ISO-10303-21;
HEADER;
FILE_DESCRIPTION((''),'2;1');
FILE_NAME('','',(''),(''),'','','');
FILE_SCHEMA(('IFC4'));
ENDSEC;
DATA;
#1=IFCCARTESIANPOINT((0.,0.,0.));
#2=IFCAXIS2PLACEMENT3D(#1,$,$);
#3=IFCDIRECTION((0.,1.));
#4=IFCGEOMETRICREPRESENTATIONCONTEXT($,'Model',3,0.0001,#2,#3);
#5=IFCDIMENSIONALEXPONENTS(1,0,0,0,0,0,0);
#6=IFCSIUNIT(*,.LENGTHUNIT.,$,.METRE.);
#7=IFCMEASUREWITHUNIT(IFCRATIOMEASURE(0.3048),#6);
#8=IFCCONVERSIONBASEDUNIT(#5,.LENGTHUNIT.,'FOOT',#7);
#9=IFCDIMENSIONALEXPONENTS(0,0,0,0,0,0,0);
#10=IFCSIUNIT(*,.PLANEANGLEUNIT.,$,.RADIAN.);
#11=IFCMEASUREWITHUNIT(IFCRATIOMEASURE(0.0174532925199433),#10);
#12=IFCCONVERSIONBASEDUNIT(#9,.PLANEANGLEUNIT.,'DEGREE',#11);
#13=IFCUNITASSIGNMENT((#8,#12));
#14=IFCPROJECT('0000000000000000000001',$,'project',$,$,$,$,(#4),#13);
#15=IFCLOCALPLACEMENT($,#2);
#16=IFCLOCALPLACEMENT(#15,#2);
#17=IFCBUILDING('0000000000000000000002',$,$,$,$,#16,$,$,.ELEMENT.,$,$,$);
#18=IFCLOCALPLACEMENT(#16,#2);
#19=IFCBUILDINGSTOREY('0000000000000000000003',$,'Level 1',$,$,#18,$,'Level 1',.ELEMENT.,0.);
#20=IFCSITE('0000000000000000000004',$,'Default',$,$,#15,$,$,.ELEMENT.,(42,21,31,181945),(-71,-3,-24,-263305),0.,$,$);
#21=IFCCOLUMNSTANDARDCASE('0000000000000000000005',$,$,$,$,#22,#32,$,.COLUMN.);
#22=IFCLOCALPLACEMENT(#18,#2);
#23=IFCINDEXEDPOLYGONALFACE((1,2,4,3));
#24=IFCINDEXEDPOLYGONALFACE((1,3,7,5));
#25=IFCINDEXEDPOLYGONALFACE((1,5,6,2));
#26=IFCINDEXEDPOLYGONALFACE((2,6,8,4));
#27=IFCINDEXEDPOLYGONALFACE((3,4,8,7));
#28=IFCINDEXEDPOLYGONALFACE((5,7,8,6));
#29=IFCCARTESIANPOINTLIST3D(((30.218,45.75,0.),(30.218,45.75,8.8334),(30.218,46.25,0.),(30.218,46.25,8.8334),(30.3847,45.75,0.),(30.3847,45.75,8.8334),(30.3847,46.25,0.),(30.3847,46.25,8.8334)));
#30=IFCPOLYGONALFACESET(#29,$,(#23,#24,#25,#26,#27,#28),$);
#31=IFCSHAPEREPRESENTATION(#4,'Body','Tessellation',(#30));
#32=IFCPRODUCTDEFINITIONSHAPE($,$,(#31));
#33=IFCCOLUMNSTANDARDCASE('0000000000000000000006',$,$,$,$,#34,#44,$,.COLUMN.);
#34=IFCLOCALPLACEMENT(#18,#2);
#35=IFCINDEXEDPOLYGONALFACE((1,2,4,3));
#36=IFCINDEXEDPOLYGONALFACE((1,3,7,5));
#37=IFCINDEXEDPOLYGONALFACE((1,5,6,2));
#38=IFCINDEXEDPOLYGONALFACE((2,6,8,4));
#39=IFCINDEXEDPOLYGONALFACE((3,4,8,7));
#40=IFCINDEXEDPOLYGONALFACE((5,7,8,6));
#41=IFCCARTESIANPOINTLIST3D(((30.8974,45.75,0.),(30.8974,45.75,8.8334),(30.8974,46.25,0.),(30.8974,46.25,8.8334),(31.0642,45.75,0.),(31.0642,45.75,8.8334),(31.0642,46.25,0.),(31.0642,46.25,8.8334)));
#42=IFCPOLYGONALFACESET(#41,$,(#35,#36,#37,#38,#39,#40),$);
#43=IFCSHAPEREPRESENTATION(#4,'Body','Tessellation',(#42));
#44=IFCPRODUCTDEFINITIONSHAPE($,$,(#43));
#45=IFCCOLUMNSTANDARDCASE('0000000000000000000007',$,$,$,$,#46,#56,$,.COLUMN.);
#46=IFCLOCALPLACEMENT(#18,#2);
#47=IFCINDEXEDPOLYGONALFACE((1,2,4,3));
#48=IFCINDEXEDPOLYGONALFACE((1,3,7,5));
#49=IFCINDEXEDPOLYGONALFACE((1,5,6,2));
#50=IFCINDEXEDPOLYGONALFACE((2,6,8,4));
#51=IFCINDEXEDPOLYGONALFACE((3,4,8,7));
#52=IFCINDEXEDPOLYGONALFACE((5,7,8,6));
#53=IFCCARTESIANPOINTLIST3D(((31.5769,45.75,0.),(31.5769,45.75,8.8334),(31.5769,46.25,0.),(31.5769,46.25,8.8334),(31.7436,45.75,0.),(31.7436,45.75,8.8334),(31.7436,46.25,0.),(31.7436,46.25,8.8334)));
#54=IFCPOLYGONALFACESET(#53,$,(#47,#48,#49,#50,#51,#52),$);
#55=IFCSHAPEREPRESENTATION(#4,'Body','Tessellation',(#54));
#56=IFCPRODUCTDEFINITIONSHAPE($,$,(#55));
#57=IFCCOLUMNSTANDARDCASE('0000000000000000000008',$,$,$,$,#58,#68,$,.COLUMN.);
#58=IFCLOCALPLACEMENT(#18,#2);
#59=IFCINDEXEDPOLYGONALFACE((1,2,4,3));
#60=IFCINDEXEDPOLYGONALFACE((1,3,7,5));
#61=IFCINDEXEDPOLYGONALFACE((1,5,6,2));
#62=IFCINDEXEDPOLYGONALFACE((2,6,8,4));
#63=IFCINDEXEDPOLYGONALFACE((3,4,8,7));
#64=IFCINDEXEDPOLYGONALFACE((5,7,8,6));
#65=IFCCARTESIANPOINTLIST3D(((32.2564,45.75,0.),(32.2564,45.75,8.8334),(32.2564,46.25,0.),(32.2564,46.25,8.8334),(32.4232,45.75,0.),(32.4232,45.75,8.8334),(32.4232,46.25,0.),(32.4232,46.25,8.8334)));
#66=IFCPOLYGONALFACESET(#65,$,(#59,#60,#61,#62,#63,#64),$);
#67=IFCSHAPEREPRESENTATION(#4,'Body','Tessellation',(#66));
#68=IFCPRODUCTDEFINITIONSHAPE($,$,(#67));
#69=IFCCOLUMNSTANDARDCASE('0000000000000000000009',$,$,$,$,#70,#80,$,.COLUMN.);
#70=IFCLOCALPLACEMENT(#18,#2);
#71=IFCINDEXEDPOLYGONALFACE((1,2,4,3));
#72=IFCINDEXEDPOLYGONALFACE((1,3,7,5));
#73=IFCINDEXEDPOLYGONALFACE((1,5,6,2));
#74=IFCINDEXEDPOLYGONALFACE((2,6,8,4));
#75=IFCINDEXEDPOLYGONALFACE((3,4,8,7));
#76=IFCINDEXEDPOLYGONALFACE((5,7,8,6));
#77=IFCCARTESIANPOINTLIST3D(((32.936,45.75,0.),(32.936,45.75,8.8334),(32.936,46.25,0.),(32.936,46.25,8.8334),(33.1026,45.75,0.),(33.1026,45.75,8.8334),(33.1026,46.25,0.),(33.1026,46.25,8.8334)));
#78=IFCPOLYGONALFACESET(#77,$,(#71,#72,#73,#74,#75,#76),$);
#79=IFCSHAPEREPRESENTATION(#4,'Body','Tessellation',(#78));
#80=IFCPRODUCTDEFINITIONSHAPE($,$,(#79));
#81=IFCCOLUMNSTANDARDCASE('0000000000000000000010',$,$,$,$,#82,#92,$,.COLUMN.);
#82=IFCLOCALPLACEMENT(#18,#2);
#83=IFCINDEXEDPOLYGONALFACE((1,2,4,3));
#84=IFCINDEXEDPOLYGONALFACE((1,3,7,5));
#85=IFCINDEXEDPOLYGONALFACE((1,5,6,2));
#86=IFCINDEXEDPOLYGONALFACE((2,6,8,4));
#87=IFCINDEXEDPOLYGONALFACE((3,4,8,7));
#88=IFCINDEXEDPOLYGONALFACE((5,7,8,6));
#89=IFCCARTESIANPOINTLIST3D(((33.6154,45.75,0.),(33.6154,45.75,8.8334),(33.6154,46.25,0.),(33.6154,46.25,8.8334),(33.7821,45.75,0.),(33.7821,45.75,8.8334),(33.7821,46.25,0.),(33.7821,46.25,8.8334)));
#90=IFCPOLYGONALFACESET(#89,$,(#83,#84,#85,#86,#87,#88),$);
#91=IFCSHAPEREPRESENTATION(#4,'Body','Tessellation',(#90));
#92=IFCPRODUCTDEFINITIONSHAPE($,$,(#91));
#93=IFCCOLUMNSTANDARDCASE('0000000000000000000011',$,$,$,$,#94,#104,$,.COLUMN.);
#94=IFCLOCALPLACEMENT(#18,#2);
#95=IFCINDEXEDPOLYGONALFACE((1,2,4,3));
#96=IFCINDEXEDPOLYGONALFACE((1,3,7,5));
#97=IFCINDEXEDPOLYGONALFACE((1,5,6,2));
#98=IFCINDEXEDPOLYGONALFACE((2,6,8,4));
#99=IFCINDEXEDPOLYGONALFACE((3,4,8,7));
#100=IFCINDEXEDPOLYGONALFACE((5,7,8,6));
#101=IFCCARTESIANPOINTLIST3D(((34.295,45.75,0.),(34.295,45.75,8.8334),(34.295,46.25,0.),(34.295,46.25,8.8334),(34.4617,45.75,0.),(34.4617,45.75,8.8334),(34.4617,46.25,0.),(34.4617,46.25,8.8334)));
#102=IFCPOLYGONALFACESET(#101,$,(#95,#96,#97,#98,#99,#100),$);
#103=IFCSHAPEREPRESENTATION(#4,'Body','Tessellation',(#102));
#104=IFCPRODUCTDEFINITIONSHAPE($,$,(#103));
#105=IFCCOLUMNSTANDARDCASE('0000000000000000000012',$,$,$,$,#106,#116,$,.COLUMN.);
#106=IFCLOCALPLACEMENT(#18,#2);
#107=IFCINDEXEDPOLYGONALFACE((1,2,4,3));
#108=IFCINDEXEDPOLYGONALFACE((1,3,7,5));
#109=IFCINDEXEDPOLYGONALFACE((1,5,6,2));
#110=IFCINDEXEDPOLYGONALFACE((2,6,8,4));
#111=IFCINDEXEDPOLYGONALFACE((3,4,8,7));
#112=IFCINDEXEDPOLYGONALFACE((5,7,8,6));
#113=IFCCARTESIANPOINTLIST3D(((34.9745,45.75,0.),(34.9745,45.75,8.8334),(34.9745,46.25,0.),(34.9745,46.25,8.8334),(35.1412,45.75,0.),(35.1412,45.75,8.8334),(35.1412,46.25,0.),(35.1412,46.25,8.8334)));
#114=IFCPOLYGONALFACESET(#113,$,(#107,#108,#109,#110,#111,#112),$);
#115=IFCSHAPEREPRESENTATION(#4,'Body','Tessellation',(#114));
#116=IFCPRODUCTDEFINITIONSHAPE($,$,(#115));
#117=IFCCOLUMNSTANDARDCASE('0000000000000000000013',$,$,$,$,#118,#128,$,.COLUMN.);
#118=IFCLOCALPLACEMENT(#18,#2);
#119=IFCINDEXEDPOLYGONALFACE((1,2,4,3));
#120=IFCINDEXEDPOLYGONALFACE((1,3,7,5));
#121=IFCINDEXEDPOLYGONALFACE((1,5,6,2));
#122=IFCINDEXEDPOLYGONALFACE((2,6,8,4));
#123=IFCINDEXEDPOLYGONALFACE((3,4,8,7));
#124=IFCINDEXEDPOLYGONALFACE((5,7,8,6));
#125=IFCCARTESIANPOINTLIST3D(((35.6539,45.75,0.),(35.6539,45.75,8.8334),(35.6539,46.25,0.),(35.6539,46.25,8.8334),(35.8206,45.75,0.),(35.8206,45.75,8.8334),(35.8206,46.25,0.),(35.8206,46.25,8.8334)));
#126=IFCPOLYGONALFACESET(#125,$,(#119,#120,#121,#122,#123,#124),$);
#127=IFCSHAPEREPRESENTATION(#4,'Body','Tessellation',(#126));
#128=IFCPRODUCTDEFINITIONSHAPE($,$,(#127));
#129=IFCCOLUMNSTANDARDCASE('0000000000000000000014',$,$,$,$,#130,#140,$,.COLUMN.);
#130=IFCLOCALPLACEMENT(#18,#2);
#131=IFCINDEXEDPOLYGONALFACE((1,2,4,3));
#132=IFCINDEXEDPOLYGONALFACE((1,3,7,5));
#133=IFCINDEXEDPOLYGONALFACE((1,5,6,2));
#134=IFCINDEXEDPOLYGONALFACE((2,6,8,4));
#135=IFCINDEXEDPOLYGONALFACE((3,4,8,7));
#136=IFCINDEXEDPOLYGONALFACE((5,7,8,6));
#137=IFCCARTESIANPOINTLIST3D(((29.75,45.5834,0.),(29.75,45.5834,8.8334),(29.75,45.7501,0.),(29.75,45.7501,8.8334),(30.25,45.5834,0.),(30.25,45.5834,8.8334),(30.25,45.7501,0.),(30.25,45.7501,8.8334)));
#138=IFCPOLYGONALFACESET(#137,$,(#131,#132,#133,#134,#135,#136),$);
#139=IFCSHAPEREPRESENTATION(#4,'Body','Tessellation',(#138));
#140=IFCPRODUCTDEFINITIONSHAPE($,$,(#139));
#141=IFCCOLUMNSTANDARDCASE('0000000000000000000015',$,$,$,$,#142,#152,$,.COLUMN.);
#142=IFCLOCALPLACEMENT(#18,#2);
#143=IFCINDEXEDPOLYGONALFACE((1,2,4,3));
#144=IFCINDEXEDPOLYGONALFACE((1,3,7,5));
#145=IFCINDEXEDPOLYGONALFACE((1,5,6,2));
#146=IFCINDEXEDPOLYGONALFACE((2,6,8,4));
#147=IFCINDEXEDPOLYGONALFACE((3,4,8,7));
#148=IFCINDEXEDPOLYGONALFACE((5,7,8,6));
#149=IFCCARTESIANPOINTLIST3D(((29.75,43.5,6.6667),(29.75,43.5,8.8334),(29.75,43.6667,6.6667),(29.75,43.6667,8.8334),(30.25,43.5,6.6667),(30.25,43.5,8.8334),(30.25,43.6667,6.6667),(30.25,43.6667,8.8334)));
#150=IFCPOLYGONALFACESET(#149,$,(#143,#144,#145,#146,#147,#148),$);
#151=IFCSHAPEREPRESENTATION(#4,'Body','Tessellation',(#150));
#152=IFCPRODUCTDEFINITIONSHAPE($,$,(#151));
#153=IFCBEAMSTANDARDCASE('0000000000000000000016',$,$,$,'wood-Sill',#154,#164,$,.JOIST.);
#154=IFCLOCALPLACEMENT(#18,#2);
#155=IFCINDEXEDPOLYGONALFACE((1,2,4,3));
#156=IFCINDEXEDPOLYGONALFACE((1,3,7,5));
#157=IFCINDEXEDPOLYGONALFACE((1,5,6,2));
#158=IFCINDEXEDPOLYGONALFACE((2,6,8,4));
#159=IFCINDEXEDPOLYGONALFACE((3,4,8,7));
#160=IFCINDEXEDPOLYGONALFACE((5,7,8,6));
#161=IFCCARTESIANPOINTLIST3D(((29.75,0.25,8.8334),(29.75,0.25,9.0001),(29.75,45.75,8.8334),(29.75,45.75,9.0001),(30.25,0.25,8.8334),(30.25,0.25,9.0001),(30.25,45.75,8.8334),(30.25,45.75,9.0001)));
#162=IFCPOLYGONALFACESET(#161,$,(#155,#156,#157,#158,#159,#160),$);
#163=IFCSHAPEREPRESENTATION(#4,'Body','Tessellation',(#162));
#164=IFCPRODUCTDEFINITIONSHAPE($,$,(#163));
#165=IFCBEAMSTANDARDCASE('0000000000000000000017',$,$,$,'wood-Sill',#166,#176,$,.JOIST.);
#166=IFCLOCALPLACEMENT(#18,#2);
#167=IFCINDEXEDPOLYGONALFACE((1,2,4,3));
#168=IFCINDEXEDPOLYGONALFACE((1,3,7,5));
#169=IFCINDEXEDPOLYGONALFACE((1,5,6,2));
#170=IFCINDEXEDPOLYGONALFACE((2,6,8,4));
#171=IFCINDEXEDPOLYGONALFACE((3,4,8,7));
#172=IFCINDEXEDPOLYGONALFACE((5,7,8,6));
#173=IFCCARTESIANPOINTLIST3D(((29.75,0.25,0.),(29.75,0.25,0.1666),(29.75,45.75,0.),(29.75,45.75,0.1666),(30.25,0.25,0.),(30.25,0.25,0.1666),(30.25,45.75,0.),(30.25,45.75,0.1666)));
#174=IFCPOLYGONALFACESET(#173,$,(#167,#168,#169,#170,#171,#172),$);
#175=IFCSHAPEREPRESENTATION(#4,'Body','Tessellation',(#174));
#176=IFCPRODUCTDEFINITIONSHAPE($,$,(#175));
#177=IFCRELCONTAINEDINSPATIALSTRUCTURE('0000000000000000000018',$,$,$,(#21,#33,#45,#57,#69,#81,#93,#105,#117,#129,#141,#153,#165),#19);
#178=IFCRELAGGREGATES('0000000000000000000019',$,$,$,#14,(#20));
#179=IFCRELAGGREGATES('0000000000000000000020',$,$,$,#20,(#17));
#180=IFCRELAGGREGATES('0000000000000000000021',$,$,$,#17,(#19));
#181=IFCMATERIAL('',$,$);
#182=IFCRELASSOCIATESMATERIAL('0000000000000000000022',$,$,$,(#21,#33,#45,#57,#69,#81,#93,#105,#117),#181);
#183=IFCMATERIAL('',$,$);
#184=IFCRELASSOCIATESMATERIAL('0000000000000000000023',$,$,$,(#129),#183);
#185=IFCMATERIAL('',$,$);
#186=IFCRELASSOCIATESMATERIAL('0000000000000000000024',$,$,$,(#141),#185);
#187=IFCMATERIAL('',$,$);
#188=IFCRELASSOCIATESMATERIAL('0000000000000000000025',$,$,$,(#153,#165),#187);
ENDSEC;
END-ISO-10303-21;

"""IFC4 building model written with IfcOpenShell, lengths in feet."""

from ifc_helpers import new_model, entity, si_unit, converted_unit, direction, frame, origin, origin_with_axes, place, context, project, spatial, rectangle, extrude, material, element, save


model = new_model("IFC4")

# Units and contexts
model_context = context("Model", 3, precision=0.0001, world=origin(), true_north=direction((0.0, 1.0)))
ifc_project = project(units=[converted_unit("LENGTHUNIT", "FOOT", entity("IfcRatioMeasure", 0.3048), si_unit("LENGTHUNIT", "METRE"), dimensions=[1, 0, 0, 0, 0, 0, 0]), converted_unit("PLANEANGLEUNIT", "DEGREE", entity("IfcRatioMeasure", 0.0174532925199433), si_unit("PLANEANGLEUNIT", "RADIAN"), dimensions=[0, 0, 0, 0, 0, 0, 0])], contexts=[model_context])

# Site, building, storey
site_placement = place(None, origin())
site = spatial("IfcSite", under=ifc_project, at=site_placement, Name="Default", CompositionType="ELEMENT", RefLatitude=(42, 21, 31, 181945), RefLongitude=(-71, -3, -24, -263305), RefElevation=0.0)
building_placement = place(site_placement, origin())
building = spatial("IfcBuilding", under=site, at=building_placement, CompositionType="ELEMENT")
storey_placement = place(building_placement, origin())
storey = spatial("IfcBuildingStorey", under=building, at=storey_placement, Name="Level 1", LongName="Level 1", CompositionType="ELEMENT", Elevation=0.0)

# Columns
ifc_material_1 = material(Name="")
placement_1 = place(storey_placement, frame((-0.25, 46.0, 0.0)))
for number, where, z_axis, x_axis in (
    (1, (30.5513, 0.0, 0.0), (0.0, 0.0, 1.0), (1.0, 0.0, 0.0)),
    (2, (31.2308, 0.0, 0.0), (0.0, 0.0, 1.0), (1.0, 0.0, 0.0)),
    (3, (31.9103, 0.0, 0.0), (0.0, 0.0, 1.0), (1.0, 0.0, 0.0)),
    (4, (32.5898, 0.0, 0.0), (0.0, 0.0, 1.0), (1.0, 0.0, 0.0)),
    (5, (33.2693, 0.0, 0.0), (0.0, 0.0, 1.0), (1.0, 0.0, 0.0)),
    (6, (33.9488, 0.0, 0.0), (0.0, 0.0, 1.0), (1.0, 0.0, 0.0)),
    (7, (34.6283, 0.0, 0.0), (0.0, 0.0, 1.0), (1.0, 0.0, 0.0)),
    (8, (35.3078, 0.0, 0.0), (0.0, 0.0, 1.0), (1.0, 0.0, 0.0)),
    (9, (35.9873, 0.0, 0.0), (0.0, 0.0, 1.0), (1.0, 0.0, 0.0)),
):
    element("IfcColumnStandardCase", number, at=place(placement_1, frame(where, z_axis=z_axis, x_axis=x_axis)), inside=storey, material=ifc_material_1, PredefinedType="COLUMN", context=model_context, shape_type="SweptSolid", body=[
        extrude(rectangle(XDim=0.1667, YDim=0.5), origin(), (0.0, 0.0, 1.0), 8.8334),
    ])
ifc_material_2 = material(Name="")
placement_2 = place(storey_placement, frame((30.0, 45.75, 0.0), z_axis=(0.0, 0.0, 1.0), x_axis=(0.0, -1.0, 0.0)))
for number, where, z_axis, x_axis in (
    (10, (0.0833, 0.0, 0.0), (0.0, 0.0, 1.0), (1.0, 0.0, 0.0)),
):
    element("IfcColumnStandardCase", number, at=place(placement_2, frame(where, z_axis=z_axis, x_axis=x_axis)), inside=storey, material=ifc_material_2, PredefinedType="COLUMN", context=model_context, shape_type="SweptSolid", body=[
        extrude(rectangle(XDim=0.1667, YDim=0.5), origin(), (0.0, 0.0, 1.0), 8.8334),
    ])
ifc_material_3 = material(Name="")
for number, where, z_axis, x_axis in (
    (11, (2.1667, 0.0, 6.6667), (0.0, 0.0, 1.0), (1.0, 0.0, 0.0)),
):
    element("IfcColumnStandardCase", number, at=place(placement_2, frame(where, z_axis=z_axis, x_axis=x_axis)), inside=storey, material=ifc_material_3, PredefinedType="COLUMN", context=model_context, shape_type="SweptSolid", body=[
        extrude(rectangle(XDim=0.1667, YDim=0.5), origin(), (0.0, 0.0, 1.0), 2.1667),
    ])

# Beams
ifc_material_4 = material(Name="")
for number, where, z_axis, x_axis in (
    (12, (0.0, 0.0, 8.9167), (1.0, 0.0, 0.0), (0.0, 0.0, 1.0)),
    (13, (0.0, 0.0, 0.0833), (1.0, 0.0, 0.0), (0.0, 0.0, 1.0)),
):
    element("IfcBeamStandardCase", number, at=place(placement_2, frame(where, z_axis=z_axis, x_axis=x_axis)), inside=storey, material=ifc_material_4, ObjectType="wood-Sill", PredefinedType="JOIST", context=model_context, shape_type="SweptSolid", body=[
        extrude(rectangle(XDim=0.1667, YDim=0.5), origin_with_axes(), (0.0, 0.0, 1.0), 45.5),
    ])

save(model, "model.ifc")
